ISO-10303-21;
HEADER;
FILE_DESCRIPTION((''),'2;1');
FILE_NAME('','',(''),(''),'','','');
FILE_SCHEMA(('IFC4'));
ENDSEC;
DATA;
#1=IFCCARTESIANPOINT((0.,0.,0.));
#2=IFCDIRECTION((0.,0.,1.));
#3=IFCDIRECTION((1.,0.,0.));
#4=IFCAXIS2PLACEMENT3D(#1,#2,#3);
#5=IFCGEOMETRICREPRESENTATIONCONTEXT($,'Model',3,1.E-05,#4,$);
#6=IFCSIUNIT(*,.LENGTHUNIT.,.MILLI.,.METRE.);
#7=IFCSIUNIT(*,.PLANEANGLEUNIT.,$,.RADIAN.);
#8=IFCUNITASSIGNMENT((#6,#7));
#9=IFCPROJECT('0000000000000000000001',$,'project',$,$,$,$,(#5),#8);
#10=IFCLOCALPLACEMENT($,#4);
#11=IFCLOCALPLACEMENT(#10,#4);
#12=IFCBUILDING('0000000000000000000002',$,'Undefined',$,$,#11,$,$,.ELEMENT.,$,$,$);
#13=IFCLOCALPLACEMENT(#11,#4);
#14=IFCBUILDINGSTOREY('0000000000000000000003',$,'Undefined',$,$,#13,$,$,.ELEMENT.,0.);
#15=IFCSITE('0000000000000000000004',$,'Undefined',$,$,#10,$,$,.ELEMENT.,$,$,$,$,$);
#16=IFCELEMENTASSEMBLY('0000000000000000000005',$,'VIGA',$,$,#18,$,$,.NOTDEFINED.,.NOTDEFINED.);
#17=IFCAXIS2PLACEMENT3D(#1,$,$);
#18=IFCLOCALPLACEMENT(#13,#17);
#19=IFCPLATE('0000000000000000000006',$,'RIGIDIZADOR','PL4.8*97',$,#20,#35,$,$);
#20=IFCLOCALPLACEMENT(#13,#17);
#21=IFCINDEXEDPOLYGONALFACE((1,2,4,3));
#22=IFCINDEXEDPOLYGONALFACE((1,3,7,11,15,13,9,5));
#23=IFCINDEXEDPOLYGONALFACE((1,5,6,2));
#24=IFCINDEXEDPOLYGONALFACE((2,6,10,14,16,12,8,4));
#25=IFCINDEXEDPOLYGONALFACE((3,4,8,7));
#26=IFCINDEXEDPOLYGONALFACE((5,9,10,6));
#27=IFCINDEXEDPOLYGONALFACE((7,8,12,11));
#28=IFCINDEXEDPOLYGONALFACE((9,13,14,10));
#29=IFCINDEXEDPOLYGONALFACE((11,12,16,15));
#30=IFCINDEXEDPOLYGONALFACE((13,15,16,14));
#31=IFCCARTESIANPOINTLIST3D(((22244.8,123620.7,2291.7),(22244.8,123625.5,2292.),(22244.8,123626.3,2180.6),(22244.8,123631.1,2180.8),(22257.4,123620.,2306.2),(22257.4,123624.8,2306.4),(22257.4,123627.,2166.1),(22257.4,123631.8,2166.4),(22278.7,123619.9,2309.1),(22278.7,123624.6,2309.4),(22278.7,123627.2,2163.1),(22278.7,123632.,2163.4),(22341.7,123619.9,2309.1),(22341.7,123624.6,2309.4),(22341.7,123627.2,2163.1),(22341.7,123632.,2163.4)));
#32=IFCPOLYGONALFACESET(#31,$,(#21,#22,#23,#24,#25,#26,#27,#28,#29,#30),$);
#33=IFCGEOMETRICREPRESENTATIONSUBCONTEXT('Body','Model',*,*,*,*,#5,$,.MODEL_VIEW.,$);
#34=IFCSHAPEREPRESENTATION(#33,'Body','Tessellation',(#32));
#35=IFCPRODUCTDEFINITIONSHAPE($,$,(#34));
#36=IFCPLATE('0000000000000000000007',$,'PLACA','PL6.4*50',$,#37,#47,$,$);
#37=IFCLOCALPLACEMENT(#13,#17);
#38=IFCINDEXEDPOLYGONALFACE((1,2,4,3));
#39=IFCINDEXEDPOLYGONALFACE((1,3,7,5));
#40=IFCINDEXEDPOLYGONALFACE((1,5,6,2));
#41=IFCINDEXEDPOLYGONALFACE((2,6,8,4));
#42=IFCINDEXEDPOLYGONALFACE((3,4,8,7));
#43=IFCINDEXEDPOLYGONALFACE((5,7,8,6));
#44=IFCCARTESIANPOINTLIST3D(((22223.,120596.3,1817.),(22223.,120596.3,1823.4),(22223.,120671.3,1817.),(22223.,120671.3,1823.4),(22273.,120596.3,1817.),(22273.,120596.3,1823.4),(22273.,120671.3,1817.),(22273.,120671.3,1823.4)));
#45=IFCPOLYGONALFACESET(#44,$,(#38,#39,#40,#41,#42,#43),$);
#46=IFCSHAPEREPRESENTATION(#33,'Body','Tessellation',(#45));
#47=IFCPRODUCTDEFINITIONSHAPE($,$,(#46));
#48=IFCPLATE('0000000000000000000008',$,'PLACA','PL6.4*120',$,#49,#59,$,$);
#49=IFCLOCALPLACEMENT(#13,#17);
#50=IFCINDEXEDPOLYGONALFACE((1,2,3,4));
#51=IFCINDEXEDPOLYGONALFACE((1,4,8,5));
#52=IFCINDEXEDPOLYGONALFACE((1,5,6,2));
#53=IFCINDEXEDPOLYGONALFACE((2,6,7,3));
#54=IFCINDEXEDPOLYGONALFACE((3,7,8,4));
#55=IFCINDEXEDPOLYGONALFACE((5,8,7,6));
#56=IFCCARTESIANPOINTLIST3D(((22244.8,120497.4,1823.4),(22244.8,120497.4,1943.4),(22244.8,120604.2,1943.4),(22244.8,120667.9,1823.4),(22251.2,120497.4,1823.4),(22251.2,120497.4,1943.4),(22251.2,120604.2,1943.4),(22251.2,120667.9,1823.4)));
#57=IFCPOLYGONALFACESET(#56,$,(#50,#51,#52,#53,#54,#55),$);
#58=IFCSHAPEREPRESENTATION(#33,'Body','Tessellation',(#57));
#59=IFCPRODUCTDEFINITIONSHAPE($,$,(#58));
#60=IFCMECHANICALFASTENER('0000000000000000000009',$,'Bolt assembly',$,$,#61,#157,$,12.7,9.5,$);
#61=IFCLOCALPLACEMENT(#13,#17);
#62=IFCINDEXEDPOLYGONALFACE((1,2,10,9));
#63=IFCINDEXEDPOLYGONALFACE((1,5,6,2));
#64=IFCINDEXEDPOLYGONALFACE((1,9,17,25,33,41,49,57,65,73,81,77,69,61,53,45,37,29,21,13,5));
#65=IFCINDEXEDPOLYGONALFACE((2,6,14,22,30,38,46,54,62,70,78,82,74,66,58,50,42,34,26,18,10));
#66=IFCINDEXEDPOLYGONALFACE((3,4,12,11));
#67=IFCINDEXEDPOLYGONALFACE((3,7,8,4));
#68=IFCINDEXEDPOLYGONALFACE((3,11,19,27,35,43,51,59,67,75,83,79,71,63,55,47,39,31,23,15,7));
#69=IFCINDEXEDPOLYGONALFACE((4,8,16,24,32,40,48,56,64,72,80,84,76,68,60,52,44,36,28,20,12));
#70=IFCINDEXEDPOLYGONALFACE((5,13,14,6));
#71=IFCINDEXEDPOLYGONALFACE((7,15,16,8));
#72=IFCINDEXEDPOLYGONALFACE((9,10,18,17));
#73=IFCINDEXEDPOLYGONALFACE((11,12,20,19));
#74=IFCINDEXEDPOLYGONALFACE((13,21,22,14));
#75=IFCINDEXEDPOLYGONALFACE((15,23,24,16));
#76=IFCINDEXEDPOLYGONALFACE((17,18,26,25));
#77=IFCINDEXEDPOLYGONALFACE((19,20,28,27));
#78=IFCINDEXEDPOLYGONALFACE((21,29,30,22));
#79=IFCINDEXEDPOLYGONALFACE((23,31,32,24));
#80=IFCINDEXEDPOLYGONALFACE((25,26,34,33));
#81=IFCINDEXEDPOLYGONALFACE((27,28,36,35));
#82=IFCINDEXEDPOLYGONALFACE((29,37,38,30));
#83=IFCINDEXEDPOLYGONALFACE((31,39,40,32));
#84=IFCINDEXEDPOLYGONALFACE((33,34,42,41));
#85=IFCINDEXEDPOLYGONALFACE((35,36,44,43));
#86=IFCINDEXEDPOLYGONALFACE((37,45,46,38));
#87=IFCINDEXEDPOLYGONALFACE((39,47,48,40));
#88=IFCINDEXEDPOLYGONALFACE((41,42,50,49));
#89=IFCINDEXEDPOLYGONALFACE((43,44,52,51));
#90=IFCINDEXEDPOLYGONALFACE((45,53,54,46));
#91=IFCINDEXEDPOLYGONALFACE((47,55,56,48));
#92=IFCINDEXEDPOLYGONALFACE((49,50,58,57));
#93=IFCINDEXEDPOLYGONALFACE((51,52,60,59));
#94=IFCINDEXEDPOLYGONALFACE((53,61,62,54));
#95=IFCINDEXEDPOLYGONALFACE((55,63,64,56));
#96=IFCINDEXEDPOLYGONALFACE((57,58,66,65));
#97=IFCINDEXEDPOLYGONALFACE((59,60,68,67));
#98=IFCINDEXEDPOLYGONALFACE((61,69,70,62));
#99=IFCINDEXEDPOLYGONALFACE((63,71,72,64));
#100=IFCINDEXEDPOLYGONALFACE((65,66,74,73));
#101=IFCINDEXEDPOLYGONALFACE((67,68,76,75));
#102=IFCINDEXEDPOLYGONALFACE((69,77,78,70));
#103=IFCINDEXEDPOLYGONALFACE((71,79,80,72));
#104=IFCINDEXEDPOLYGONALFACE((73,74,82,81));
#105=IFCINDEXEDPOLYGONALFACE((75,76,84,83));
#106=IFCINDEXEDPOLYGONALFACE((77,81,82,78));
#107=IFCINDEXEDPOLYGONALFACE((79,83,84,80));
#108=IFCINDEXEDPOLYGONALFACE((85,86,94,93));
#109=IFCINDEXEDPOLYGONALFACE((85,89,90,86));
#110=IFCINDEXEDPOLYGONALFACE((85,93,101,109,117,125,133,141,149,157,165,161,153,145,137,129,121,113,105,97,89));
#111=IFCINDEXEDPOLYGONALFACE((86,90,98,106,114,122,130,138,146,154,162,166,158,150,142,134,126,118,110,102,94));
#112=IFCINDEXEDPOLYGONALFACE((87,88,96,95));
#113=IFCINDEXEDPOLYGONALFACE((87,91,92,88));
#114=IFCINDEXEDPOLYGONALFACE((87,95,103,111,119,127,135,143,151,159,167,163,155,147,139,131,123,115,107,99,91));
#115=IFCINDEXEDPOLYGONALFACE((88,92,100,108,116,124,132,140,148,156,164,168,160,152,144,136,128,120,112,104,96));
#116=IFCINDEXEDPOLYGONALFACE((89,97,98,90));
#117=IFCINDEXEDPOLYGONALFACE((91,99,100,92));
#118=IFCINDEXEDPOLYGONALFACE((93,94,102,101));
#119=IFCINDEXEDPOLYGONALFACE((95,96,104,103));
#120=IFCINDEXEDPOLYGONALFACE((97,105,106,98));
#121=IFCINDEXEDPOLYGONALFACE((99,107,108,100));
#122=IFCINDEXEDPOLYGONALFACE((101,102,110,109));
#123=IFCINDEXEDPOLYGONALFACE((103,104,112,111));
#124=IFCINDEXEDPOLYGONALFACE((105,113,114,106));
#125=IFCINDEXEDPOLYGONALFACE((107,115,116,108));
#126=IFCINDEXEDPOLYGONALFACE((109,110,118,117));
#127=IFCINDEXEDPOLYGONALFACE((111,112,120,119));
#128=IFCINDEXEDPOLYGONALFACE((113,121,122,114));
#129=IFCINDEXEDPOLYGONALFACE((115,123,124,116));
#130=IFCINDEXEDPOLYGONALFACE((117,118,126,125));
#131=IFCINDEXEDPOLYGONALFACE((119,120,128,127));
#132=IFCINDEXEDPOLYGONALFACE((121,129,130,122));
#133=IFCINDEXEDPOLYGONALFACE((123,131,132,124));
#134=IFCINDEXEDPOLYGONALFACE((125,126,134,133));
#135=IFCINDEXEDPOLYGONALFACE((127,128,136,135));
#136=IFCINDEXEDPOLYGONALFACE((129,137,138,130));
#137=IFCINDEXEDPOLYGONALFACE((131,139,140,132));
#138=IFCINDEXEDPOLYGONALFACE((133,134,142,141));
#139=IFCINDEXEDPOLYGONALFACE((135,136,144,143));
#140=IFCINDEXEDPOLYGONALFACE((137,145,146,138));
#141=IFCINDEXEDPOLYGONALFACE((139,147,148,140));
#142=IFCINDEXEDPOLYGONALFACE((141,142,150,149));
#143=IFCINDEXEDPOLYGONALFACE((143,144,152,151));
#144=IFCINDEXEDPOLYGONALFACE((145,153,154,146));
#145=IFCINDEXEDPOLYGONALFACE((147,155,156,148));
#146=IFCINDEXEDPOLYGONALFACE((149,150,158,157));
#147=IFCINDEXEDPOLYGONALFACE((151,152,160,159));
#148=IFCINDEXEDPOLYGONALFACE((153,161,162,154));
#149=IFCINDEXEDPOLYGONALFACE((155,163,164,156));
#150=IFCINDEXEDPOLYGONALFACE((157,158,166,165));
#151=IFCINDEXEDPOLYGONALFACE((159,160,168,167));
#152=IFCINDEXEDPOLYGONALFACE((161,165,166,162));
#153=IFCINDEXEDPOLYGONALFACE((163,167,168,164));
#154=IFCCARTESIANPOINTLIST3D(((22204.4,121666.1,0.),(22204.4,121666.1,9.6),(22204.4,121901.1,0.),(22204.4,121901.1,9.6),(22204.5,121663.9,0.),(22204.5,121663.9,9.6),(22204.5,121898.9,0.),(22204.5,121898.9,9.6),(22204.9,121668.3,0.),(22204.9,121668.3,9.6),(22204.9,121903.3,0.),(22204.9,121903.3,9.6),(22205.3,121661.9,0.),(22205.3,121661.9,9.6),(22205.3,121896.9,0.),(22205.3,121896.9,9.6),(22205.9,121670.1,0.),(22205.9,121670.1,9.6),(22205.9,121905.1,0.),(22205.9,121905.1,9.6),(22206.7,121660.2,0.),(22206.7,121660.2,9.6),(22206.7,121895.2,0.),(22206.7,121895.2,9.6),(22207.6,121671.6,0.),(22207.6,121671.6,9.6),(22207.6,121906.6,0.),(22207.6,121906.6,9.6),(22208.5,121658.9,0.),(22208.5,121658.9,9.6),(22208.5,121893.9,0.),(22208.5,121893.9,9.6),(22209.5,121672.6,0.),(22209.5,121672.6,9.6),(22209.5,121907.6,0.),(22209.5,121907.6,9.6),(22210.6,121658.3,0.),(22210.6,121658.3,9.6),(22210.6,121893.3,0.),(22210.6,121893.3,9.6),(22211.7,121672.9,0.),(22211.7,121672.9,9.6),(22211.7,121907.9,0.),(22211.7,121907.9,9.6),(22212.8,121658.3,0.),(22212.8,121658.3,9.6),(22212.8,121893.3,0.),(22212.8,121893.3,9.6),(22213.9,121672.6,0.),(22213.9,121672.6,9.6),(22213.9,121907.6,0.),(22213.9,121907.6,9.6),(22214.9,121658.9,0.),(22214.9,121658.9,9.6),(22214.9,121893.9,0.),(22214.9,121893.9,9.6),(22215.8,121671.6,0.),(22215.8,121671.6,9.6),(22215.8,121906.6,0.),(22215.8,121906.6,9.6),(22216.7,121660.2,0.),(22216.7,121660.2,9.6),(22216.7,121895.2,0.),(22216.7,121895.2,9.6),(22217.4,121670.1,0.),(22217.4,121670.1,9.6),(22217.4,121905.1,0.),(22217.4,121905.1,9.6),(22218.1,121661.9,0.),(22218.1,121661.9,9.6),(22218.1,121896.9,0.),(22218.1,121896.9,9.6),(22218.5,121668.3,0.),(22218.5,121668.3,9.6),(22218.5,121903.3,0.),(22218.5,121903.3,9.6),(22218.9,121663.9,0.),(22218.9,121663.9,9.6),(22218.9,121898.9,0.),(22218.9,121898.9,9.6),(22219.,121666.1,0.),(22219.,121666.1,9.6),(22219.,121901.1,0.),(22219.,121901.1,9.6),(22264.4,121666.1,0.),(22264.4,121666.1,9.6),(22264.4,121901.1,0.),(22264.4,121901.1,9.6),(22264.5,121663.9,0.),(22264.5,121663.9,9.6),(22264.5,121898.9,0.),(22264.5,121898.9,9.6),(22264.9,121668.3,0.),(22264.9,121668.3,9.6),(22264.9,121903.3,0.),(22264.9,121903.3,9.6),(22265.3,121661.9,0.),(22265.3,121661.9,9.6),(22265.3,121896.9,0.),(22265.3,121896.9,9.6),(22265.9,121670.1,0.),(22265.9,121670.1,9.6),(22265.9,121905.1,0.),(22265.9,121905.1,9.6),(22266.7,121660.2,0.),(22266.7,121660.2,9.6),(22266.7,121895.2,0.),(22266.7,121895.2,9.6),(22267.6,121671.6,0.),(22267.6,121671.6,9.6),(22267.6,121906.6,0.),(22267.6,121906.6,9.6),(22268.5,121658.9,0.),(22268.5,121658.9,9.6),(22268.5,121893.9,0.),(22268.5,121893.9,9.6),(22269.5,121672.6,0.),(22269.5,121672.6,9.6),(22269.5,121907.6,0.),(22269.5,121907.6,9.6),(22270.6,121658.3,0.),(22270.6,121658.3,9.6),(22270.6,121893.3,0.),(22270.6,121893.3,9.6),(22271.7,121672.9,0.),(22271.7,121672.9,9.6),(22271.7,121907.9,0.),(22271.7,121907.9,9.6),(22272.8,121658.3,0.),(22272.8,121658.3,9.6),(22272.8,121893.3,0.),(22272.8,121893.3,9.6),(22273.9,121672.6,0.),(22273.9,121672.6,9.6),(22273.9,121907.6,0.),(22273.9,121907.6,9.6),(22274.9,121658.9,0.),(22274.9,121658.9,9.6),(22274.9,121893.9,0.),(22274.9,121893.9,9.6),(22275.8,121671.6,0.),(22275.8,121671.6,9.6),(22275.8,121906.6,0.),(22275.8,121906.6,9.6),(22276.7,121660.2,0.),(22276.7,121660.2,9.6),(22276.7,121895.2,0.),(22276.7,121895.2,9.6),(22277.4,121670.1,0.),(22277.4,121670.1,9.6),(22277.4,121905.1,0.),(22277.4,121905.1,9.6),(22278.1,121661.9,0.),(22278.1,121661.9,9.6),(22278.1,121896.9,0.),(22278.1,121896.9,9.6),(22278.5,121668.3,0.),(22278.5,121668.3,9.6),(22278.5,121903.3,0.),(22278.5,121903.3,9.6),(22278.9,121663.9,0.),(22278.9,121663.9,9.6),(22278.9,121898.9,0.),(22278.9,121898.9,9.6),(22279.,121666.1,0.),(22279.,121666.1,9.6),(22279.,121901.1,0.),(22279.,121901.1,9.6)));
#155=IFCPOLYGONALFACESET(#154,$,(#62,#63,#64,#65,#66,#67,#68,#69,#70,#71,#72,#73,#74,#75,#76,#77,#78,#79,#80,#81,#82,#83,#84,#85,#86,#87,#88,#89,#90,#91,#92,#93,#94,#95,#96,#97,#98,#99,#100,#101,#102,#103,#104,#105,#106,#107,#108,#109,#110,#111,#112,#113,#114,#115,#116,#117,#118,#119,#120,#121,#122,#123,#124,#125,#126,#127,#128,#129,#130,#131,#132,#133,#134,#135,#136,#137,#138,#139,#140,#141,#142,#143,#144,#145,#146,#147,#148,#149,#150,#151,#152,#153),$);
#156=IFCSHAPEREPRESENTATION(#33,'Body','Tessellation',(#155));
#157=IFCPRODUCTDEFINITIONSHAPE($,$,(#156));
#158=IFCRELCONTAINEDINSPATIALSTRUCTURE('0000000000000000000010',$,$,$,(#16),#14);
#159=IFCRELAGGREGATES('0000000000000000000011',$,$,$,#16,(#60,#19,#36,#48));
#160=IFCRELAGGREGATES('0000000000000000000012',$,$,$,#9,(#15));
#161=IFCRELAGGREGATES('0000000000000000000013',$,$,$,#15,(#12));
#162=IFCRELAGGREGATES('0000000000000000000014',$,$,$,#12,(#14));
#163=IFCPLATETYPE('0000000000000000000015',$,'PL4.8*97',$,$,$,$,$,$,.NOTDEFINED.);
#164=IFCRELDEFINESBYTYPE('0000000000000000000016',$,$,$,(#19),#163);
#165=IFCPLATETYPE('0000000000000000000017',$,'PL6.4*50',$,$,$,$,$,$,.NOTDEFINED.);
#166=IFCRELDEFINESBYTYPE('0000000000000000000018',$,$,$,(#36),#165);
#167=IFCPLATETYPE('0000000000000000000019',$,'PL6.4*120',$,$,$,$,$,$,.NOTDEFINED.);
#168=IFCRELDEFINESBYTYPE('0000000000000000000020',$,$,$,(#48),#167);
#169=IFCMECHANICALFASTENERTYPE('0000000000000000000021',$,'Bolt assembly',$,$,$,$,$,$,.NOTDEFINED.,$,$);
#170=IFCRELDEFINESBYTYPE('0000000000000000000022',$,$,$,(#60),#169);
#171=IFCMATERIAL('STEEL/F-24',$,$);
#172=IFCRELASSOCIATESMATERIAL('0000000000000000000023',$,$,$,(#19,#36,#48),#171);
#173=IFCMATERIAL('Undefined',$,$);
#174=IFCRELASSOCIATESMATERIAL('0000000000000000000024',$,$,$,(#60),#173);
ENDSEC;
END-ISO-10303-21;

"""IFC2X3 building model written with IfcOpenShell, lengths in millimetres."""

from ifc_helpers import new_model, si_unit, frame, origin_with_axes, origin_2d_with_axis, place, context, subcontext, project, spatial, polyline, circle, outline, extrude, source, transform, mapped, material, type_object, element, aggregate, save


model = new_model("IFC2X3")

# Units and contexts
model_context = context("Model", 3, precision=1e-05, world=origin_with_axes())
body_context = subcontext(model_context, "Body", "Model", "MODEL_VIEW")
ifc_project = project(units=[si_unit("LENGTHUNIT", "METRE", prefix="MILLI"), si_unit("PLANEANGLEUNIT", "RADIAN")], contexts=[model_context])

# Site, building, storey
site_placement = place(None, origin_with_axes())
site = spatial("IfcSite", under=ifc_project, at=site_placement, Name="Undefined", CompositionType="ELEMENT")
building_placement = place(site_placement, origin_with_axes())
building = spatial("IfcBuilding", under=site, at=building_placement, Name="Undefined", CompositionType="ELEMENT")
storey_placement = place(building_placement, origin_with_axes())
storey = spatial("IfcBuildingStorey", under=building, at=storey_placement, Name="Undefined", CompositionType="ELEMENT", Elevation=0.0)

# Element assembly
assembly_1_placement = place(storey_placement, origin_with_axes())
assembly_1 = element("IfcElementAssembly", 1, at=assembly_1_placement, inside=storey, Name="VIGA", AssemblyPlace="NOTDEFINED", PredefinedType="NOTDEFINED")
ifc_material_1 = material(Name="STEEL/F-24")

# Plates
plate_type_1 = type_object("IfcPlateType", Name="PL4.8*97", PredefinedType="NOTDEFINED")
plate_1_placement = place(assembly_1_placement, frame((22341.7, 123622.3, 2309.3), z_axis=(0.0, -0.998752, -0.04995), x_axis=(-1.0, 0.0, 0.0)))
plate_1 = element("IfcPlate", 2, at=plate_1_placement, type_object=plate_type_1, material=ifc_material_1, Name="RIGIDIZADOR", Description="PL4.8*97", context=body_context, shape_type="SweptSolid", body=[
    extrude(outline(polyline([(0.0, 0.0), (63.0, 0.0), (84.3, 3.0), (96.8, 17.4), (96.8, 128.7), (84.3, 143.2), (63.0, 146.2), (0.0, 146.2), (0.0, 0.0)])), frame((0.0, 0.0, -2.4), z_axis=(0.0, 0.0, 1.0), x_axis=(1.0, 0.0, 0.0)), (0.0, 0.0, 1.0), 4.8),
])
plate_type_2 = type_object("IfcPlateType", Name="PL6.4*50", PredefinedType="NOTDEFINED")
plate_2_placement = place(assembly_1_placement, frame((22223.0, 120671.3, 1820.2), z_axis=(0.0, 0.0, 1.0), x_axis=(0.0, -1.0, 0.0)))
plate_2 = element("IfcPlate", 3, at=plate_2_placement, type_object=plate_type_2, material=ifc_material_1, Name="PLACA", Description="PL6.4*50", context=body_context, shape_type="SweptSolid", body=[
    extrude(outline(polyline([(0.0, 0.0), (75.0, 0.0), (75.0, 50.0), (0.0, 50.0), (0.0, 0.0)])), frame((0.0, 0.0, -3.2), z_axis=(0.0, 0.0, 1.0), x_axis=(1.0, 0.0, 0.0)), (0.0, 0.0, 1.0), 6.4),
])
plate_type_3 = type_object("IfcPlateType", Name="PL6.4*120", PredefinedType="NOTDEFINED")
plate_3_placement = place(assembly_1_placement, frame((22248.0, 120604.2, 1943.4), z_axis=(1.0, 0.0, 0.0), x_axis=(0.0, -1.0, 0.0)))
plate_3 = element("IfcPlate", 4, at=plate_3_placement, type_object=plate_type_3, material=ifc_material_1, Name="PLACA", Description="PL6.4*120", context=body_context, shape_type="SweptSolid", body=[
    extrude(outline(polyline([(0.0, 0.0), (106.8, 0.0), (106.8, 120.0), (-63.7, 120.0), (0.0, 0.0)])), frame((0.0, 0.0, -3.2), z_axis=(0.0, 0.0, 1.0), x_axis=(1.0, 0.0, 0.0)), (0.0, 0.0, 1.0), 6.4),
])

# Shared definitions
ifc_material_2 = material(Name="Undefined")
mechanical_fastener_type = type_object("IfcMechanicalFastenerType", Name="Bolt assembly")

# Mechanical fastener
shared_shape_1 = source(origin_with_axes(), body_context, "Body", "SweptSolid", [
    extrude(circle(Radius=7.3, at=origin_2d_with_axis()), frame((0.0, -9.5, 0.0), z_axis=(0.0, 1.0, 0.0), x_axis=(1.0, 0.0, 0.0)), (0.0, 0.0, 1.0), 9.6),
])
mechanical_fastener_1_placement = place(assembly_1_placement, frame((22241.7, 121665.6, 9.5), z_axis=(1.0, 0.0, 0.0), x_axis=(0.0, 1.0, 0.0)))
mechanical_fastener_1 = element("IfcMechanicalFastener", 5, at=mechanical_fastener_1_placement, type_object=mechanical_fastener_type, material=ifc_material_2, Name="Bolt assembly", NominalDiameter=12.7, NominalLength=9.5, context=body_context, shape_type="MappedRepresentation", body=[
    mapped(shared_shape_1, transform((0.0, 0.0, -30.0))),
    mapped(shared_shape_1, transform((235.0, 0.0, -30.0))),
    mapped(shared_shape_1, transform((0.0, 0.0, 30.0))),
    mapped(shared_shape_1, transform((235.0, 0.0, 30.0))),
])
aggregate(assembly_1, [mechanical_fastener_1, plate_1, plate_2, plate_3])

save(model, "model.ifc")
